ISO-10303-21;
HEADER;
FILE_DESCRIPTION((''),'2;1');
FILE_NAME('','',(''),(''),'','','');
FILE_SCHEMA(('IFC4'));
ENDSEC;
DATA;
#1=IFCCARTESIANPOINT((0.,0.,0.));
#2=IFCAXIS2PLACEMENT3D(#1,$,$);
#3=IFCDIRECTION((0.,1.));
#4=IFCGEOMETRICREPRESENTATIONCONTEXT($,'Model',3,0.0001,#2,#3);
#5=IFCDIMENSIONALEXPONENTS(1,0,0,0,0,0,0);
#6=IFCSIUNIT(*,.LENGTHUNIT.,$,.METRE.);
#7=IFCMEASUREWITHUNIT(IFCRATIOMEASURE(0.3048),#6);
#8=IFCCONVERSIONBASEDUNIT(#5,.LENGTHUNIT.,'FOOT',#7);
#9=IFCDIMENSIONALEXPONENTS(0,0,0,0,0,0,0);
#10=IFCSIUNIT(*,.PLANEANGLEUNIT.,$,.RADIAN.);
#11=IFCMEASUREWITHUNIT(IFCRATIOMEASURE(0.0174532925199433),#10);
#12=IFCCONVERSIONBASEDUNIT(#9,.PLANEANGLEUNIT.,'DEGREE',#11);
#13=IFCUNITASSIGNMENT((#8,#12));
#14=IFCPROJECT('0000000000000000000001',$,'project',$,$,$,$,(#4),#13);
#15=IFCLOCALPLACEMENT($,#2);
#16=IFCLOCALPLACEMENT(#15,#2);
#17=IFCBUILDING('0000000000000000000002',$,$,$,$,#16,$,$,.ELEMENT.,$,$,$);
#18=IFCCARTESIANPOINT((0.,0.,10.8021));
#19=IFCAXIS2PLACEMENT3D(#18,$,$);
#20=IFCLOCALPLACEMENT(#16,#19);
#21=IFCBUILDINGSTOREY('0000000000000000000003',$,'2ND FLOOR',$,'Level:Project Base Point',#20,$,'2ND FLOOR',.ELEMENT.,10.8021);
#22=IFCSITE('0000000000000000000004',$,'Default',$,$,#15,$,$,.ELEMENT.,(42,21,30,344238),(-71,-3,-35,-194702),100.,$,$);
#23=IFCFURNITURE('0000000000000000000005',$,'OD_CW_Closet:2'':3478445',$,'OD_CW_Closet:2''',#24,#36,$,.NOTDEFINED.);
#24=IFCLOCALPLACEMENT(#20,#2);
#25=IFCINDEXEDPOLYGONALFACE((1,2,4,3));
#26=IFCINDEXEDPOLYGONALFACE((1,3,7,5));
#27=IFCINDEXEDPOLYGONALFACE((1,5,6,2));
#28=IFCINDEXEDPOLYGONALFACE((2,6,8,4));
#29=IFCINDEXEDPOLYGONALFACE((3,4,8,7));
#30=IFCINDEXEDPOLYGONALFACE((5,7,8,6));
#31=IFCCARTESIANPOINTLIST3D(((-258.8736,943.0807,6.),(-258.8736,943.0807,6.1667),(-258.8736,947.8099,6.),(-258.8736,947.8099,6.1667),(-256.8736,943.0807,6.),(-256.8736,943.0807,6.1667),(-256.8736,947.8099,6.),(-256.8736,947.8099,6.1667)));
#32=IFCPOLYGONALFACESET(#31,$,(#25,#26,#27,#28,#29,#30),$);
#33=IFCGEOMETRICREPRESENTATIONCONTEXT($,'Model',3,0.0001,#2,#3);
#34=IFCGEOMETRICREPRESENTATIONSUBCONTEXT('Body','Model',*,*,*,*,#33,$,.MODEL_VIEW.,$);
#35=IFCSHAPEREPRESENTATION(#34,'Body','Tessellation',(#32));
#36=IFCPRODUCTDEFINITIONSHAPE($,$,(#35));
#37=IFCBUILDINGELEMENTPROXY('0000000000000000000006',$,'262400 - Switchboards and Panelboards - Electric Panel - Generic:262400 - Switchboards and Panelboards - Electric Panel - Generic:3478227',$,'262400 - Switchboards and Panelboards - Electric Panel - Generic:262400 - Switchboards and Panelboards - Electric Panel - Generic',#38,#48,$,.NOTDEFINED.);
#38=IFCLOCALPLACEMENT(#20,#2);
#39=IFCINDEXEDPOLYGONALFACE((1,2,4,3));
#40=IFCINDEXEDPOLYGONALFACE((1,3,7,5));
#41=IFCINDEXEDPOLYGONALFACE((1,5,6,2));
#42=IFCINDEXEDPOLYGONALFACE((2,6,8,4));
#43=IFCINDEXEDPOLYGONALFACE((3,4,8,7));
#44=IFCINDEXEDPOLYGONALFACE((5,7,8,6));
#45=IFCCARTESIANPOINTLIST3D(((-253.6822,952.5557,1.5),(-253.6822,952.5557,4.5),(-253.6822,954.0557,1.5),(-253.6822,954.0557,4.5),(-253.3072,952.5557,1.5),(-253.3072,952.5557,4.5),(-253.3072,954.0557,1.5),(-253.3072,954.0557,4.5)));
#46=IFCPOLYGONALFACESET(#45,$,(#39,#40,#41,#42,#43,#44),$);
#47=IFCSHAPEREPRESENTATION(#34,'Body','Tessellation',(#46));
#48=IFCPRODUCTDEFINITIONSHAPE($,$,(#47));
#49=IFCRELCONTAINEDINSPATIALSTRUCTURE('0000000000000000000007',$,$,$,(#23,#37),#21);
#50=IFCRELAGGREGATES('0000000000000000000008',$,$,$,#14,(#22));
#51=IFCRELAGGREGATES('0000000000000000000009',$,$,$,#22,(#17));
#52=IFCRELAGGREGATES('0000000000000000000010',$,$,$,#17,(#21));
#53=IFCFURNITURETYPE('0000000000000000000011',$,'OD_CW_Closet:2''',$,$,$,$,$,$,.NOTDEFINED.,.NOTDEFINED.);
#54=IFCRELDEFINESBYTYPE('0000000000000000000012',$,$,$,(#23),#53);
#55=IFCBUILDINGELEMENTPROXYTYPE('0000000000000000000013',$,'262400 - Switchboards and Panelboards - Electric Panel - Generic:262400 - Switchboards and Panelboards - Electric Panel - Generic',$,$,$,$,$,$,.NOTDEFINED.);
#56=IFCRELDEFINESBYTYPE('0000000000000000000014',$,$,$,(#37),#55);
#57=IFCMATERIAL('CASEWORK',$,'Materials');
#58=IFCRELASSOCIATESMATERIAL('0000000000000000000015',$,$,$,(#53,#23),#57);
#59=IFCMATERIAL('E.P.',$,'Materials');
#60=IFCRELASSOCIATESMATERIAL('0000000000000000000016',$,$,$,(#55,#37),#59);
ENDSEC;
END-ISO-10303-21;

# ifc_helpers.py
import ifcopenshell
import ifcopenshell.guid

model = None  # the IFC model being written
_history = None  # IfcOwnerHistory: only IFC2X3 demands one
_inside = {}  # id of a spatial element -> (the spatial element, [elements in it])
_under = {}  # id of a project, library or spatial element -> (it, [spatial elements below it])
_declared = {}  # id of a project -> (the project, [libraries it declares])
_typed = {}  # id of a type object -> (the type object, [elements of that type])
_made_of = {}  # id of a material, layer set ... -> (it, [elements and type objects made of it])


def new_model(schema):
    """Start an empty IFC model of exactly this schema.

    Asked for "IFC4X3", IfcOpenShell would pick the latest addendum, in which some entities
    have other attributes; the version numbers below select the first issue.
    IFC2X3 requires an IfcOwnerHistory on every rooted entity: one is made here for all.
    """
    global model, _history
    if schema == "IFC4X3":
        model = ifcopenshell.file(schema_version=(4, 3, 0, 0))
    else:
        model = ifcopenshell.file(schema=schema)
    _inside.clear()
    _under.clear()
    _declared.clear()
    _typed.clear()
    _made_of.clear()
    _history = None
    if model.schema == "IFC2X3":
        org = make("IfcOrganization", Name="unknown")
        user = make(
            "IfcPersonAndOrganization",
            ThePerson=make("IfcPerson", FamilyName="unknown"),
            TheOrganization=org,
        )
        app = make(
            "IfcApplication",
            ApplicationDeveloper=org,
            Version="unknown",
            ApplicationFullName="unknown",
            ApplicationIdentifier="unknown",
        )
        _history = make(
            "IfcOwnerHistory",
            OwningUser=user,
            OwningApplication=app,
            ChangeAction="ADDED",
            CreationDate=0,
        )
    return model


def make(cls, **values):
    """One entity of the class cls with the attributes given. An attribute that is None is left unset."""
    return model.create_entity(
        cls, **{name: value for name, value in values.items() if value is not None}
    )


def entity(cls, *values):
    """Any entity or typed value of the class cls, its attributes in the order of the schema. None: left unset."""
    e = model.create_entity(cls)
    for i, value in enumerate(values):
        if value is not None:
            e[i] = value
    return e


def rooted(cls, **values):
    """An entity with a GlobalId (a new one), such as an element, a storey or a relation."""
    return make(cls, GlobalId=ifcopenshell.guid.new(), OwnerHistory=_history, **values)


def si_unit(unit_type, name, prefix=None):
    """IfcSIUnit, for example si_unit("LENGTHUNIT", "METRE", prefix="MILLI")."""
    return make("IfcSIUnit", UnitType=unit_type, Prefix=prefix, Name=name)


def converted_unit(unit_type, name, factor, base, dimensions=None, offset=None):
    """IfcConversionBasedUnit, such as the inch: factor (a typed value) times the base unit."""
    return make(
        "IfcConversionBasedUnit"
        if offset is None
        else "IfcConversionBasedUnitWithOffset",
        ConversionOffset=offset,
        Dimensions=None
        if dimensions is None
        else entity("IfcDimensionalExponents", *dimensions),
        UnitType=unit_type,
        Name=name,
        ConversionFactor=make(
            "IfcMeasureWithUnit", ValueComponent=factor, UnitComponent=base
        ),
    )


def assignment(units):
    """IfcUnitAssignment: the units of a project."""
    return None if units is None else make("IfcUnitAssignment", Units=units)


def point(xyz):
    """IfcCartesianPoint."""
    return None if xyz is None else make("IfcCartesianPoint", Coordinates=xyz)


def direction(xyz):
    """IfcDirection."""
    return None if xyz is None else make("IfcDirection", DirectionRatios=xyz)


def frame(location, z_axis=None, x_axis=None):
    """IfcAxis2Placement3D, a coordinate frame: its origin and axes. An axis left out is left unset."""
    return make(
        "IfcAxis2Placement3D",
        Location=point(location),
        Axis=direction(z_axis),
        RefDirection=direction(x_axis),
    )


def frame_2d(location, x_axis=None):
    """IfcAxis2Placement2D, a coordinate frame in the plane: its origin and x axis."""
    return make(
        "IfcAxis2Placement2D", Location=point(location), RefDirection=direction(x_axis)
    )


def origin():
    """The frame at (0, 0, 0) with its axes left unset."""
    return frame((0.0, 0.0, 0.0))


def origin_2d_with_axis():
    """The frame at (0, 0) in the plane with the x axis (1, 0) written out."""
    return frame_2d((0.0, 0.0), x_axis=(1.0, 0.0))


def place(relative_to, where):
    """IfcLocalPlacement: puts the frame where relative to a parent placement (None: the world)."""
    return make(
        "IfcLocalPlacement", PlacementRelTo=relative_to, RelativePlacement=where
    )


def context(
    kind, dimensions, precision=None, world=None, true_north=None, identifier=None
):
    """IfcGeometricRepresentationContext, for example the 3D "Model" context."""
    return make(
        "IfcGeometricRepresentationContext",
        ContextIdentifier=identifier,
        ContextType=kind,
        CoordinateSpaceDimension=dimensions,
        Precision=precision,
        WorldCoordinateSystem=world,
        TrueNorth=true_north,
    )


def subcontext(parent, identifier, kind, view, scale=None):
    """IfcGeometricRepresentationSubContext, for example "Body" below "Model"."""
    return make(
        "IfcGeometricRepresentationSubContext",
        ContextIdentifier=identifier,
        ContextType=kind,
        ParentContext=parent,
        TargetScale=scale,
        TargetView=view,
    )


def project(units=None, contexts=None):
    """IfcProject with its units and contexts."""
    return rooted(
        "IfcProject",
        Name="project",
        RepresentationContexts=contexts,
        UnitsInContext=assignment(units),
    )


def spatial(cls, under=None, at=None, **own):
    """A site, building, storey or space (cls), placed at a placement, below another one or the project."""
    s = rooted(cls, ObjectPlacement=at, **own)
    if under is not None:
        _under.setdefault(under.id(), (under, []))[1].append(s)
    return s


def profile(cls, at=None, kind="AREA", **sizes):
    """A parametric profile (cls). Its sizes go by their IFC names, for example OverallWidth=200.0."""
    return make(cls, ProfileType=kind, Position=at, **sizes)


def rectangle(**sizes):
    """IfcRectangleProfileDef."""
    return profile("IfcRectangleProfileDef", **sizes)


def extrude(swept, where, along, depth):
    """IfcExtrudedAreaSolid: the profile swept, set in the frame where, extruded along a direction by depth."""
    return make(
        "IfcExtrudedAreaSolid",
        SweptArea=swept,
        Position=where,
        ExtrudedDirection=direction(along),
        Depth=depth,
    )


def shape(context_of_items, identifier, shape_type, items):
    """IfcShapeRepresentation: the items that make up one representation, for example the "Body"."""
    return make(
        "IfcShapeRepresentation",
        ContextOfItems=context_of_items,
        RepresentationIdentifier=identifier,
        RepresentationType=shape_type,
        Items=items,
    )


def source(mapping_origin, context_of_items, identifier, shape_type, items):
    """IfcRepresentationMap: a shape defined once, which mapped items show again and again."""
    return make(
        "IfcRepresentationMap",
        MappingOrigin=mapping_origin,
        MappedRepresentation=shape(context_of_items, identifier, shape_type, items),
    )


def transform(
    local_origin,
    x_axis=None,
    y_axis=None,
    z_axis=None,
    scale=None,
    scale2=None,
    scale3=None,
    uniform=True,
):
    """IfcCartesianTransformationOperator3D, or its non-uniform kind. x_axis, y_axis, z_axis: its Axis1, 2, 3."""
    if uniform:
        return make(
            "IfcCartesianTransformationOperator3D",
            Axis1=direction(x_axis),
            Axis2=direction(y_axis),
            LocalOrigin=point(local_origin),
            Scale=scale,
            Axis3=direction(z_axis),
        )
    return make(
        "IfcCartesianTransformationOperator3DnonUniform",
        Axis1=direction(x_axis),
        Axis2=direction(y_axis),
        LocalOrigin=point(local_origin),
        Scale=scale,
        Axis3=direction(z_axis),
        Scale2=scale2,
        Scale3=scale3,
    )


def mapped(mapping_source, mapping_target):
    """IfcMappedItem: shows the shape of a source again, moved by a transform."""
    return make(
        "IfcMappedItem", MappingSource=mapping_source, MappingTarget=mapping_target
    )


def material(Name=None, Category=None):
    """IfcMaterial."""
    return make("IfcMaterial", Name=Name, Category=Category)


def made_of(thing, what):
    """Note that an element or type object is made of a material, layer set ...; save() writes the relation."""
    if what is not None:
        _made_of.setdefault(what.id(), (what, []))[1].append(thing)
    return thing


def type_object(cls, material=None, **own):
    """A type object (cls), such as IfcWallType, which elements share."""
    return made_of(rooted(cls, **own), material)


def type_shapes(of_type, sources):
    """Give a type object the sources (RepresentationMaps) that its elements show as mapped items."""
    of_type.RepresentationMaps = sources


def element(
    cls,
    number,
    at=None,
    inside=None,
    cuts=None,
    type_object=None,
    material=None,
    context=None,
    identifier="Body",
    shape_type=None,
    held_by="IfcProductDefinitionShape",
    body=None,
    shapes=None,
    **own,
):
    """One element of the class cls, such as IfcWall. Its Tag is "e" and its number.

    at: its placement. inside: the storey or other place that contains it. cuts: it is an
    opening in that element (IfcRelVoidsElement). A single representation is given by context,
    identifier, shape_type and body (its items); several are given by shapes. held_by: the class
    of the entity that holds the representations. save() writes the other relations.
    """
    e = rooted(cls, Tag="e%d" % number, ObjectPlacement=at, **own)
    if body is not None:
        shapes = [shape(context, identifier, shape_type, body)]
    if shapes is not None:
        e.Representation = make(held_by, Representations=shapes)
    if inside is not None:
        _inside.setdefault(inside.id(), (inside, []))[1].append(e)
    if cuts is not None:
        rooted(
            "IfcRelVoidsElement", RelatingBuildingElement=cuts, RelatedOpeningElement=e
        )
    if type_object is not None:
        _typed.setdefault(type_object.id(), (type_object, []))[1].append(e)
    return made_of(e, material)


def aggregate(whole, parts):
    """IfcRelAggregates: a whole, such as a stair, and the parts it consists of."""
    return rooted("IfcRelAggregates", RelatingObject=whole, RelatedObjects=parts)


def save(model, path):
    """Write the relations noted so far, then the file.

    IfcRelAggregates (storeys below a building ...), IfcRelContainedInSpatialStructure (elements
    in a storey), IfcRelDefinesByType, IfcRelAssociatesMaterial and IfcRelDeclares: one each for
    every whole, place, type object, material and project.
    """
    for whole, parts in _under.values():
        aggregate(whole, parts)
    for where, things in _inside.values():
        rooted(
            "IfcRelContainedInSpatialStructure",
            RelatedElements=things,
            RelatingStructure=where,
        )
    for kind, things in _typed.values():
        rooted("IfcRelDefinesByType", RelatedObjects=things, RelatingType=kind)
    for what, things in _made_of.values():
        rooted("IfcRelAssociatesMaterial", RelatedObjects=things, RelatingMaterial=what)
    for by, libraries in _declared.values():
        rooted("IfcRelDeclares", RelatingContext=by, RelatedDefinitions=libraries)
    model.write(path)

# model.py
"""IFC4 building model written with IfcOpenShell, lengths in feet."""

from ifc_helpers import new_model, entity, si_unit, converted_unit, direction, frame, origin, origin_2d_with_axis, place, context, subcontext, project, spatial, rectangle, extrude, source, transform, mapped, material, type_object, type_shapes, element, save


model = new_model("IFC4")

# Units and contexts
model_context_1 = context("Model", 3, precision=0.0001, world=origin(), true_north=direction((0.0, 1.0)))
model_context_2 = context("Model", 3, precision=0.0001, world=origin(), true_north=direction((0.0, 1.0)))
body_context = subcontext(model_context_2, "Body", "Model", "MODEL_VIEW")
ifc_project = project(units=[converted_unit("LENGTHUNIT", "FOOT", entity("IfcRatioMeasure", 0.3048), si_unit("LENGTHUNIT", "METRE"), dimensions=[1, 0, 0, 0, 0, 0, 0]), converted_unit("PLANEANGLEUNIT", "DEGREE", entity("IfcRatioMeasure", 0.0174532925199433), si_unit("PLANEANGLEUNIT", "RADIAN"), dimensions=[0, 0, 0, 0, 0, 0, 0])], contexts=[model_context_1])

# Site, building, storey
site_placement = place(None, origin())
site = spatial("IfcSite", under=ifc_project, at=site_placement, Name="Default", CompositionType="ELEMENT", RefLatitude=(42, 21, 30, 344238), RefLongitude=(-71, -3, -35, -194702), RefElevation=100.0)
building_placement = place(site_placement, origin())
building = spatial("IfcBuilding", under=site, at=building_placement, CompositionType="ELEMENT")
storey_placement = place(building_placement, frame((0.0, 0.0, 10.8021)))
storey = spatial("IfcBuildingStorey", under=building, at=storey_placement, Name="2ND FLOOR", ObjectType="Level:Project Base Point", LongName="2ND FLOOR", CompositionType="ELEMENT", Elevation=10.8021)

# Furniture
ifc_material_1 = material(Name="CASEWORK", Category="Materials")
furniture_type_1 = type_object("IfcFurnitureType", Name="OD_CW_Closet:2'", AssemblyPlace="NOTDEFINED", PredefinedType="NOTDEFINED", material=ifc_material_1)
shared_shape_1 = source(origin(), body_context, "Body", "SweptSolid", [
    extrude(rectangle(XDim=2.0, YDim=4.7292, at=origin_2d_with_axis()), frame((2.3646, 1.0, 0.0), z_axis=(0.0, 0.0, 1.0), x_axis=(0.0, -1.0, 0.0)), (0.0, 0.0, 1.0), 0.1667),
])
type_shapes(furniture_type_1, [shared_shape_1])
furniture_1_placement = place(storey_placement, frame((-258.8736, 947.8099, 6.0), z_axis=(0.0, 0.0, 1.0), x_axis=(0.0, -1.0, 0.0)))
element("IfcFurniture", 1, at=furniture_1_placement, inside=storey, type_object=furniture_type_1, material=ifc_material_1, Name="OD_CW_Closet:2':3478445", ObjectType="OD_CW_Closet:2'", PredefinedType="NOTDEFINED", context=body_context, shape_type="MappedRepresentation", body=[
    mapped(shared_shape_1, transform((0.0, 0.0, 0.0), scale=1.0)),
])

# Building element proxy
ifc_material_2 = material(Name="E.P.", Category="Materials")
building_element_proxy_type_1 = type_object("IfcBuildingElementProxyType", Name="262400 - Switchboards and Panelboards - Electric Panel - Generic:262400 - Switchboards and Panelboards - Electric Panel - Generic", PredefinedType="NOTDEFINED", material=ifc_material_2)
shared_shape_2 = source(origin(), body_context, "Body", "SweptSolid", [
    extrude(rectangle(XDim=1.5, YDim=0.375, at=origin_2d_with_axis()), frame((0.75, 0.1875, 0.0), z_axis=(0.0, 0.0, 1.0), x_axis=(-1.0, 0.0, 0.0)), (0.0, 0.0, 1.0), 3.0),
])
type_shapes(building_element_proxy_type_1, [shared_shape_2])
proxy_1_placement = place(storey_placement, frame((-253.3072, 952.5557, 1.5), z_axis=(0.0, 0.0, 1.0), x_axis=(0.0, 1.0, 0.0)))
element("IfcBuildingElementProxy", 2, at=proxy_1_placement, inside=storey, type_object=building_element_proxy_type_1, material=ifc_material_2, Name="262400 - Switchboards and Panelboards - Electric Panel - Generic:262400 - Switchboards and Panelboards - Electric Panel - Generic:3478227", ObjectType="262400 - Switchboards and Panelboards - Electric Panel - Generic:262400 - Switchboards and Panelboards - Electric Panel - Generic", PredefinedType="NOTDEFINED", context=body_context, shape_type="MappedRepresentation", body=[
    mapped(shared_shape_2, transform((0.0, 0.0, 0.0), scale=1.0)),
])

save(model, "model.ifc")
